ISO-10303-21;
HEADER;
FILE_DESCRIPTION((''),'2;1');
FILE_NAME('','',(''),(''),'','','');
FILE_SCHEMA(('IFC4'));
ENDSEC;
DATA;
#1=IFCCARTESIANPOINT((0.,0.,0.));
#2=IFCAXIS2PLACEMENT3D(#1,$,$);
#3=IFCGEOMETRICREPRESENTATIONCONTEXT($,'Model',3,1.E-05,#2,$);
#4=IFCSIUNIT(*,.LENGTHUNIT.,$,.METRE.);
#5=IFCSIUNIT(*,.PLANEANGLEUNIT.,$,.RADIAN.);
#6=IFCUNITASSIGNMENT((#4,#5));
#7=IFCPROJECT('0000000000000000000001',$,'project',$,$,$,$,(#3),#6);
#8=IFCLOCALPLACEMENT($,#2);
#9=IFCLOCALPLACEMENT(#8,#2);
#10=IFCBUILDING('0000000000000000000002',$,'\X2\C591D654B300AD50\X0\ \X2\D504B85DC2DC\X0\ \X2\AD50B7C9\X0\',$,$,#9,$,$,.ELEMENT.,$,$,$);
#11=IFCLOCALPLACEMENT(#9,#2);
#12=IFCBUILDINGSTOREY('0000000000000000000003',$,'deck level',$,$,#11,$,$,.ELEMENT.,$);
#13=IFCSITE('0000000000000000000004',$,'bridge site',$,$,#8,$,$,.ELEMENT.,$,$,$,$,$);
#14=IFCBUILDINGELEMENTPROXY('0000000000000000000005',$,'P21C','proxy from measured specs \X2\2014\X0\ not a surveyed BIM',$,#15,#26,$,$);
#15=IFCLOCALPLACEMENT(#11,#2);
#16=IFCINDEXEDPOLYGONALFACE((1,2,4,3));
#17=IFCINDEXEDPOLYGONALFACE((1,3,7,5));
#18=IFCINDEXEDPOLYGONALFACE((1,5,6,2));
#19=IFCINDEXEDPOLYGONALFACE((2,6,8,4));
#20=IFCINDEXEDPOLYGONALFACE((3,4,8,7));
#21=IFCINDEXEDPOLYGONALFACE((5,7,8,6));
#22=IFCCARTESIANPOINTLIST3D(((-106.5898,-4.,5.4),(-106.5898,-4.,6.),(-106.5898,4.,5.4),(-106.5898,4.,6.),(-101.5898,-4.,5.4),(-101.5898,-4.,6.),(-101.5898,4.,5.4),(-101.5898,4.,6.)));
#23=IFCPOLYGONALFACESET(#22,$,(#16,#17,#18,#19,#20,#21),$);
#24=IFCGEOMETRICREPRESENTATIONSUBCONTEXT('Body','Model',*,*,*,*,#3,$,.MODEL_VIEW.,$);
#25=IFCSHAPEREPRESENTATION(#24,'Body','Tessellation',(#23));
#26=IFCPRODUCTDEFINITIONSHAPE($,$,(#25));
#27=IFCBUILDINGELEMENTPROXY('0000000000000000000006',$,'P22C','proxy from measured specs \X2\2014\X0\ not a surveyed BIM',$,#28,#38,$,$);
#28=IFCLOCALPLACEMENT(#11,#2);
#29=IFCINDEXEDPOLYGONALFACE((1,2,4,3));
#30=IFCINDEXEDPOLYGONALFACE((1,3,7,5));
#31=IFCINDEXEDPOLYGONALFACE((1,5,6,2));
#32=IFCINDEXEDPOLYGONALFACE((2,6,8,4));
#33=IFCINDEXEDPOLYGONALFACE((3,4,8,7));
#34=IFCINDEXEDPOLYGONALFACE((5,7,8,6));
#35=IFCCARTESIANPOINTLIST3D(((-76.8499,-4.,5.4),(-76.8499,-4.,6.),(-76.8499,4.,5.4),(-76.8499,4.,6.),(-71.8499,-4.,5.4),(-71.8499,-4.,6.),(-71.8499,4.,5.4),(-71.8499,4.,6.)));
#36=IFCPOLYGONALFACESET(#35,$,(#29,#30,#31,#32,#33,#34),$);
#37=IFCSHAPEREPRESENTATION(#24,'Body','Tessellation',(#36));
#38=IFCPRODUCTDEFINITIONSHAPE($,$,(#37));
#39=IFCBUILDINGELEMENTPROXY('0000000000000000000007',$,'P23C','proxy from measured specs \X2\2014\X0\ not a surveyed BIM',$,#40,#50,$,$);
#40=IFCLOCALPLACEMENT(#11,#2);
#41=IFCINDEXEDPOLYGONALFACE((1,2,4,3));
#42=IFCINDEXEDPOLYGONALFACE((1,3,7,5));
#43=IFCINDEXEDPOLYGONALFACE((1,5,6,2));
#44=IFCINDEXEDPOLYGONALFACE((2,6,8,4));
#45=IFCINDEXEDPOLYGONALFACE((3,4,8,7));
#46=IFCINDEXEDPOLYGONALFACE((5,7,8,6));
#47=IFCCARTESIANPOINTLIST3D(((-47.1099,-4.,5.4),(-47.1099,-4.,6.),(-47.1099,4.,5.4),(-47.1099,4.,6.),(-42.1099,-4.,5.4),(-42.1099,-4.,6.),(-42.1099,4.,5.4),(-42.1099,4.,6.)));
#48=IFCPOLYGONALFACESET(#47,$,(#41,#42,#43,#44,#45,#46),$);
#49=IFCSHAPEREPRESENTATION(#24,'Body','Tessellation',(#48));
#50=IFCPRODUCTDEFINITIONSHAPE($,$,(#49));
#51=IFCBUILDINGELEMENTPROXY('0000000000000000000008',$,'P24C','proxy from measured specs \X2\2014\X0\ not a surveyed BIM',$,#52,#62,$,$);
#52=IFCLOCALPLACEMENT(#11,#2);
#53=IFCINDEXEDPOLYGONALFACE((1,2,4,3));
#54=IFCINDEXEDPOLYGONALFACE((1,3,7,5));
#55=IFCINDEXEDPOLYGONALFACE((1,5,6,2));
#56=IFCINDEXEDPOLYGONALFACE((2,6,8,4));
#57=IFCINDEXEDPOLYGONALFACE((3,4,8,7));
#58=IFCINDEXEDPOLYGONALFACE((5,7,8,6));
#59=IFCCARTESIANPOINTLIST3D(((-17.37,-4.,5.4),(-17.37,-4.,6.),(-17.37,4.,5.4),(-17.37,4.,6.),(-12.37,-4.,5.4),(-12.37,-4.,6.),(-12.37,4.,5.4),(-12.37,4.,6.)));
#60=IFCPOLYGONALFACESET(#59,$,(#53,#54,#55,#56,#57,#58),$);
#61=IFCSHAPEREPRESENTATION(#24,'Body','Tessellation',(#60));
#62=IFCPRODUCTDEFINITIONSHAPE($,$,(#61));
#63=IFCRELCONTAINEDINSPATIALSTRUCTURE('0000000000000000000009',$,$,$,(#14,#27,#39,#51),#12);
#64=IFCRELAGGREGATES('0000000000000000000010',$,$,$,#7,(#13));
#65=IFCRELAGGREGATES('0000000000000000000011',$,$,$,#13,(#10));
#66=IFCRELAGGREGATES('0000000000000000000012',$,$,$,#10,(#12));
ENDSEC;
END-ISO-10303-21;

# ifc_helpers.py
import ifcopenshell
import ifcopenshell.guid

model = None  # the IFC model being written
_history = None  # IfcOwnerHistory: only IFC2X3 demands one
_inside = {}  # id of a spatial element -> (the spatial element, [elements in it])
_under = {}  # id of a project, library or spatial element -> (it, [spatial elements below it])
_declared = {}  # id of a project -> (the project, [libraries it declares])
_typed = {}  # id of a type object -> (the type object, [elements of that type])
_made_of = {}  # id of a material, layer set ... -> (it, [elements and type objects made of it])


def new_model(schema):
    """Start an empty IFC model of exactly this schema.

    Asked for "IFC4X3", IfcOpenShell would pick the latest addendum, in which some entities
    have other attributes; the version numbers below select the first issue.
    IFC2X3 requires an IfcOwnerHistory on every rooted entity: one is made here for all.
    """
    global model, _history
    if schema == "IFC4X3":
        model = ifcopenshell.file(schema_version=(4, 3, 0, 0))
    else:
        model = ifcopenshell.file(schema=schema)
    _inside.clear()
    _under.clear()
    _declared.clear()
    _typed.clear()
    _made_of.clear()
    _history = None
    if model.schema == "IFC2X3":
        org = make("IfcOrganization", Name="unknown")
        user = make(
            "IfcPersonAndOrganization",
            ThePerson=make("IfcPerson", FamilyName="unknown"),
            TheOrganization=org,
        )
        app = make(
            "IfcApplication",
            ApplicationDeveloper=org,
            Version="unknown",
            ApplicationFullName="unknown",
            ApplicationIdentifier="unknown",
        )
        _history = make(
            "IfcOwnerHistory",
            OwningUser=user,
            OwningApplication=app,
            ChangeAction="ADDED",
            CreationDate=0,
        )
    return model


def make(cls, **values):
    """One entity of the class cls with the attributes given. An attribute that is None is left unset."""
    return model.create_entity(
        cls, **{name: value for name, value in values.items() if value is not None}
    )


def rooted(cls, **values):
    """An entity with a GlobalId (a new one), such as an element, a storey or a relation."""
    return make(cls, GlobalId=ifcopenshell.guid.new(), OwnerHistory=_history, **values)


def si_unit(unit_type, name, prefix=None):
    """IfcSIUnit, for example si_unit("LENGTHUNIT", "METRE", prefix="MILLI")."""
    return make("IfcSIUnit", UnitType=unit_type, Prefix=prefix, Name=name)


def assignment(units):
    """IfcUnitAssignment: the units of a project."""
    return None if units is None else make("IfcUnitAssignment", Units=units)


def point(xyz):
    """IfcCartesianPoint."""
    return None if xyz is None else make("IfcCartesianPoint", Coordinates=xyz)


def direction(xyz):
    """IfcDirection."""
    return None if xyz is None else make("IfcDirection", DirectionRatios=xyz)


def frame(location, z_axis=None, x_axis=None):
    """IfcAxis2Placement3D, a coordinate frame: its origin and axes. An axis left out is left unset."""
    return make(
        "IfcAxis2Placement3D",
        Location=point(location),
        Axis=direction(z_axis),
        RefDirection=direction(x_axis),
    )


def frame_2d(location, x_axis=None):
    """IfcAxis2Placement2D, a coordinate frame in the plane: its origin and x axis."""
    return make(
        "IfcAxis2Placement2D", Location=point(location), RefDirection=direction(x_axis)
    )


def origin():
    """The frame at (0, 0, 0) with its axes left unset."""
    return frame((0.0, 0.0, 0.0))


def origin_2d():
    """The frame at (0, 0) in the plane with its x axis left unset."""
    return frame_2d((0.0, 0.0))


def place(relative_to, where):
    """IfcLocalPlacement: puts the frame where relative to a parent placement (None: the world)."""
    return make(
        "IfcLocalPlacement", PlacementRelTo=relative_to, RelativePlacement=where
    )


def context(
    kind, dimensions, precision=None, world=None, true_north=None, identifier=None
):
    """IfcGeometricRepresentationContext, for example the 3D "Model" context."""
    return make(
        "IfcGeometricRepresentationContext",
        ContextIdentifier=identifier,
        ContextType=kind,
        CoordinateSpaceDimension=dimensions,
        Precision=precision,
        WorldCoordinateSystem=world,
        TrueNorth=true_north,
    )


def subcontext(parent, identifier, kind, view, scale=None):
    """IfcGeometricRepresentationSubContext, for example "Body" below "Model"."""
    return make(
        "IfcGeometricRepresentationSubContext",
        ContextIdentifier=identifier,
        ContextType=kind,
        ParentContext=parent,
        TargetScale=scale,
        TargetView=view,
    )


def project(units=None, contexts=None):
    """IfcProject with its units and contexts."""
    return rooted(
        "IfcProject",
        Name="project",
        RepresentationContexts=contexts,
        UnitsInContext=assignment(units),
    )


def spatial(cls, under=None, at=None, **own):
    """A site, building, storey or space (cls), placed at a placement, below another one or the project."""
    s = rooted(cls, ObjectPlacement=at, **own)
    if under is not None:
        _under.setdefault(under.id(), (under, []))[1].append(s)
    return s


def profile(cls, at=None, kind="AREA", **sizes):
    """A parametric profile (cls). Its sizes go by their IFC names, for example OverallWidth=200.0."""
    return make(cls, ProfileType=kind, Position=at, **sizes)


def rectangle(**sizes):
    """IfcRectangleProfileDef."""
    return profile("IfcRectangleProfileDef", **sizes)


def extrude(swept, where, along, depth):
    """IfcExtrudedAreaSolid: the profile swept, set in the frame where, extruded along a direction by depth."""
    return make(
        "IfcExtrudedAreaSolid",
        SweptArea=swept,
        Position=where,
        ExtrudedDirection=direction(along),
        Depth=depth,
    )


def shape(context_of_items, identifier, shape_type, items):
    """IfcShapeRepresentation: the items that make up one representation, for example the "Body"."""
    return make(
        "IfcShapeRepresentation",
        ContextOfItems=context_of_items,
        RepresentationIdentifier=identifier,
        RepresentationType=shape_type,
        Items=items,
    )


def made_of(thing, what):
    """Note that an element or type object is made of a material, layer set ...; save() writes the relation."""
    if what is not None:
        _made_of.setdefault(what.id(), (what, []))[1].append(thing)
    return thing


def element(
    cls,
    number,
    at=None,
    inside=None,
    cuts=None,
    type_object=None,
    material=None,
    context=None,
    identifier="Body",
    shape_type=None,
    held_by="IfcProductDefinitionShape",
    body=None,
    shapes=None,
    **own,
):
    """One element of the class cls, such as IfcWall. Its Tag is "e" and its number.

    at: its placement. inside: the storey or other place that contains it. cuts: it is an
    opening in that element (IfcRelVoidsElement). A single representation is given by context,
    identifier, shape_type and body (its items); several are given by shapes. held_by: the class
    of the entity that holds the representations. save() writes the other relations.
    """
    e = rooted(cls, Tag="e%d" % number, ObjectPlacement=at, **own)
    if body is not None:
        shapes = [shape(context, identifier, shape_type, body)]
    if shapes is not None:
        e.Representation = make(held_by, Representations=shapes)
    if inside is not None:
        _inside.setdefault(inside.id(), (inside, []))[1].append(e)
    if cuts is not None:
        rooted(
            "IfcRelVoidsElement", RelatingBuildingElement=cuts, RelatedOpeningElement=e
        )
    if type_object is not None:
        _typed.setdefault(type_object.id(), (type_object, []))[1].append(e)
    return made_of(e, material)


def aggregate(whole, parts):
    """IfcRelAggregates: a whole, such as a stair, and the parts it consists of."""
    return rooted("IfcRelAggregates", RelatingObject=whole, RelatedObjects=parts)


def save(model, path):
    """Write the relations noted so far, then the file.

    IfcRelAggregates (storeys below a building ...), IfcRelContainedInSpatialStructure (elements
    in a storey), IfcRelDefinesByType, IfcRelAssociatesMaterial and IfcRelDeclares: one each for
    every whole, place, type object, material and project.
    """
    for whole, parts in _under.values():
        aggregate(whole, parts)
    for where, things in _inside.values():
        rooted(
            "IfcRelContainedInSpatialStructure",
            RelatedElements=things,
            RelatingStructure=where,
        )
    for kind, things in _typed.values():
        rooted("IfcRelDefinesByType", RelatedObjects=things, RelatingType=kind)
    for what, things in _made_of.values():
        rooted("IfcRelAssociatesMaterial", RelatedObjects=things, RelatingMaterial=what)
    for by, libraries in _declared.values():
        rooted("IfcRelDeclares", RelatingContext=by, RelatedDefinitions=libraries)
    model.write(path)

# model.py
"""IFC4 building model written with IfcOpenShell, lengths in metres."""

from ifc_helpers import new_model, si_unit, frame, origin, origin_2d, place, context, subcontext, project, spatial, rectangle, extrude, element, save


model = new_model("IFC4")

# Units and contexts
model_context = context("Model", 3, precision=1e-05, world=origin())
body_context = subcontext(model_context, "Body", "Model", "MODEL_VIEW")
ifc_project = project(units=[si_unit("LENGTHUNIT", "METRE"), si_unit("PLANEANGLEUNIT", "RADIAN")], contexts=[model_context])

# Site, building, storey
site_placement = place(None, origin())
site = spatial("IfcSite", under=ifc_project, at=site_placement, Name="bridge site", CompositionType="ELEMENT")
building_placement = place(site_placement, origin())
building = spatial("IfcBuilding", under=site, at=building_placement, Name="양화대교 프록시 교량", CompositionType="ELEMENT")
storey_placement = place(building_placement, origin())
storey = spatial("IfcBuildingStorey", under=building, at=storey_placement, Name="deck level", CompositionType="ELEMENT")

# Building element proxies
for number, where, name in (
    (1, (-104.0898, 0.0, 5.4), "P21C"),
    (2, (-74.3499, 0.0, 5.4), "P22C"),
    (3, (-44.6099, 0.0, 5.4), "P23C"),
    (4, (-14.87, 0.0, 5.4), "P24C"),
):
    element("IfcBuildingElementProxy", number, at=place(storey_placement, frame(where)), inside=storey, Name=name, Description="proxy from measured specs — not a surveyed BIM", context=body_context, shape_type="SweptSolid", body=[
        extrude(rectangle(XDim=5.0, YDim=8.0, at=origin_2d()), origin(), (0.0, 0.0, 1.0), 0.6),
    ])

save(model, "model.ifc")
